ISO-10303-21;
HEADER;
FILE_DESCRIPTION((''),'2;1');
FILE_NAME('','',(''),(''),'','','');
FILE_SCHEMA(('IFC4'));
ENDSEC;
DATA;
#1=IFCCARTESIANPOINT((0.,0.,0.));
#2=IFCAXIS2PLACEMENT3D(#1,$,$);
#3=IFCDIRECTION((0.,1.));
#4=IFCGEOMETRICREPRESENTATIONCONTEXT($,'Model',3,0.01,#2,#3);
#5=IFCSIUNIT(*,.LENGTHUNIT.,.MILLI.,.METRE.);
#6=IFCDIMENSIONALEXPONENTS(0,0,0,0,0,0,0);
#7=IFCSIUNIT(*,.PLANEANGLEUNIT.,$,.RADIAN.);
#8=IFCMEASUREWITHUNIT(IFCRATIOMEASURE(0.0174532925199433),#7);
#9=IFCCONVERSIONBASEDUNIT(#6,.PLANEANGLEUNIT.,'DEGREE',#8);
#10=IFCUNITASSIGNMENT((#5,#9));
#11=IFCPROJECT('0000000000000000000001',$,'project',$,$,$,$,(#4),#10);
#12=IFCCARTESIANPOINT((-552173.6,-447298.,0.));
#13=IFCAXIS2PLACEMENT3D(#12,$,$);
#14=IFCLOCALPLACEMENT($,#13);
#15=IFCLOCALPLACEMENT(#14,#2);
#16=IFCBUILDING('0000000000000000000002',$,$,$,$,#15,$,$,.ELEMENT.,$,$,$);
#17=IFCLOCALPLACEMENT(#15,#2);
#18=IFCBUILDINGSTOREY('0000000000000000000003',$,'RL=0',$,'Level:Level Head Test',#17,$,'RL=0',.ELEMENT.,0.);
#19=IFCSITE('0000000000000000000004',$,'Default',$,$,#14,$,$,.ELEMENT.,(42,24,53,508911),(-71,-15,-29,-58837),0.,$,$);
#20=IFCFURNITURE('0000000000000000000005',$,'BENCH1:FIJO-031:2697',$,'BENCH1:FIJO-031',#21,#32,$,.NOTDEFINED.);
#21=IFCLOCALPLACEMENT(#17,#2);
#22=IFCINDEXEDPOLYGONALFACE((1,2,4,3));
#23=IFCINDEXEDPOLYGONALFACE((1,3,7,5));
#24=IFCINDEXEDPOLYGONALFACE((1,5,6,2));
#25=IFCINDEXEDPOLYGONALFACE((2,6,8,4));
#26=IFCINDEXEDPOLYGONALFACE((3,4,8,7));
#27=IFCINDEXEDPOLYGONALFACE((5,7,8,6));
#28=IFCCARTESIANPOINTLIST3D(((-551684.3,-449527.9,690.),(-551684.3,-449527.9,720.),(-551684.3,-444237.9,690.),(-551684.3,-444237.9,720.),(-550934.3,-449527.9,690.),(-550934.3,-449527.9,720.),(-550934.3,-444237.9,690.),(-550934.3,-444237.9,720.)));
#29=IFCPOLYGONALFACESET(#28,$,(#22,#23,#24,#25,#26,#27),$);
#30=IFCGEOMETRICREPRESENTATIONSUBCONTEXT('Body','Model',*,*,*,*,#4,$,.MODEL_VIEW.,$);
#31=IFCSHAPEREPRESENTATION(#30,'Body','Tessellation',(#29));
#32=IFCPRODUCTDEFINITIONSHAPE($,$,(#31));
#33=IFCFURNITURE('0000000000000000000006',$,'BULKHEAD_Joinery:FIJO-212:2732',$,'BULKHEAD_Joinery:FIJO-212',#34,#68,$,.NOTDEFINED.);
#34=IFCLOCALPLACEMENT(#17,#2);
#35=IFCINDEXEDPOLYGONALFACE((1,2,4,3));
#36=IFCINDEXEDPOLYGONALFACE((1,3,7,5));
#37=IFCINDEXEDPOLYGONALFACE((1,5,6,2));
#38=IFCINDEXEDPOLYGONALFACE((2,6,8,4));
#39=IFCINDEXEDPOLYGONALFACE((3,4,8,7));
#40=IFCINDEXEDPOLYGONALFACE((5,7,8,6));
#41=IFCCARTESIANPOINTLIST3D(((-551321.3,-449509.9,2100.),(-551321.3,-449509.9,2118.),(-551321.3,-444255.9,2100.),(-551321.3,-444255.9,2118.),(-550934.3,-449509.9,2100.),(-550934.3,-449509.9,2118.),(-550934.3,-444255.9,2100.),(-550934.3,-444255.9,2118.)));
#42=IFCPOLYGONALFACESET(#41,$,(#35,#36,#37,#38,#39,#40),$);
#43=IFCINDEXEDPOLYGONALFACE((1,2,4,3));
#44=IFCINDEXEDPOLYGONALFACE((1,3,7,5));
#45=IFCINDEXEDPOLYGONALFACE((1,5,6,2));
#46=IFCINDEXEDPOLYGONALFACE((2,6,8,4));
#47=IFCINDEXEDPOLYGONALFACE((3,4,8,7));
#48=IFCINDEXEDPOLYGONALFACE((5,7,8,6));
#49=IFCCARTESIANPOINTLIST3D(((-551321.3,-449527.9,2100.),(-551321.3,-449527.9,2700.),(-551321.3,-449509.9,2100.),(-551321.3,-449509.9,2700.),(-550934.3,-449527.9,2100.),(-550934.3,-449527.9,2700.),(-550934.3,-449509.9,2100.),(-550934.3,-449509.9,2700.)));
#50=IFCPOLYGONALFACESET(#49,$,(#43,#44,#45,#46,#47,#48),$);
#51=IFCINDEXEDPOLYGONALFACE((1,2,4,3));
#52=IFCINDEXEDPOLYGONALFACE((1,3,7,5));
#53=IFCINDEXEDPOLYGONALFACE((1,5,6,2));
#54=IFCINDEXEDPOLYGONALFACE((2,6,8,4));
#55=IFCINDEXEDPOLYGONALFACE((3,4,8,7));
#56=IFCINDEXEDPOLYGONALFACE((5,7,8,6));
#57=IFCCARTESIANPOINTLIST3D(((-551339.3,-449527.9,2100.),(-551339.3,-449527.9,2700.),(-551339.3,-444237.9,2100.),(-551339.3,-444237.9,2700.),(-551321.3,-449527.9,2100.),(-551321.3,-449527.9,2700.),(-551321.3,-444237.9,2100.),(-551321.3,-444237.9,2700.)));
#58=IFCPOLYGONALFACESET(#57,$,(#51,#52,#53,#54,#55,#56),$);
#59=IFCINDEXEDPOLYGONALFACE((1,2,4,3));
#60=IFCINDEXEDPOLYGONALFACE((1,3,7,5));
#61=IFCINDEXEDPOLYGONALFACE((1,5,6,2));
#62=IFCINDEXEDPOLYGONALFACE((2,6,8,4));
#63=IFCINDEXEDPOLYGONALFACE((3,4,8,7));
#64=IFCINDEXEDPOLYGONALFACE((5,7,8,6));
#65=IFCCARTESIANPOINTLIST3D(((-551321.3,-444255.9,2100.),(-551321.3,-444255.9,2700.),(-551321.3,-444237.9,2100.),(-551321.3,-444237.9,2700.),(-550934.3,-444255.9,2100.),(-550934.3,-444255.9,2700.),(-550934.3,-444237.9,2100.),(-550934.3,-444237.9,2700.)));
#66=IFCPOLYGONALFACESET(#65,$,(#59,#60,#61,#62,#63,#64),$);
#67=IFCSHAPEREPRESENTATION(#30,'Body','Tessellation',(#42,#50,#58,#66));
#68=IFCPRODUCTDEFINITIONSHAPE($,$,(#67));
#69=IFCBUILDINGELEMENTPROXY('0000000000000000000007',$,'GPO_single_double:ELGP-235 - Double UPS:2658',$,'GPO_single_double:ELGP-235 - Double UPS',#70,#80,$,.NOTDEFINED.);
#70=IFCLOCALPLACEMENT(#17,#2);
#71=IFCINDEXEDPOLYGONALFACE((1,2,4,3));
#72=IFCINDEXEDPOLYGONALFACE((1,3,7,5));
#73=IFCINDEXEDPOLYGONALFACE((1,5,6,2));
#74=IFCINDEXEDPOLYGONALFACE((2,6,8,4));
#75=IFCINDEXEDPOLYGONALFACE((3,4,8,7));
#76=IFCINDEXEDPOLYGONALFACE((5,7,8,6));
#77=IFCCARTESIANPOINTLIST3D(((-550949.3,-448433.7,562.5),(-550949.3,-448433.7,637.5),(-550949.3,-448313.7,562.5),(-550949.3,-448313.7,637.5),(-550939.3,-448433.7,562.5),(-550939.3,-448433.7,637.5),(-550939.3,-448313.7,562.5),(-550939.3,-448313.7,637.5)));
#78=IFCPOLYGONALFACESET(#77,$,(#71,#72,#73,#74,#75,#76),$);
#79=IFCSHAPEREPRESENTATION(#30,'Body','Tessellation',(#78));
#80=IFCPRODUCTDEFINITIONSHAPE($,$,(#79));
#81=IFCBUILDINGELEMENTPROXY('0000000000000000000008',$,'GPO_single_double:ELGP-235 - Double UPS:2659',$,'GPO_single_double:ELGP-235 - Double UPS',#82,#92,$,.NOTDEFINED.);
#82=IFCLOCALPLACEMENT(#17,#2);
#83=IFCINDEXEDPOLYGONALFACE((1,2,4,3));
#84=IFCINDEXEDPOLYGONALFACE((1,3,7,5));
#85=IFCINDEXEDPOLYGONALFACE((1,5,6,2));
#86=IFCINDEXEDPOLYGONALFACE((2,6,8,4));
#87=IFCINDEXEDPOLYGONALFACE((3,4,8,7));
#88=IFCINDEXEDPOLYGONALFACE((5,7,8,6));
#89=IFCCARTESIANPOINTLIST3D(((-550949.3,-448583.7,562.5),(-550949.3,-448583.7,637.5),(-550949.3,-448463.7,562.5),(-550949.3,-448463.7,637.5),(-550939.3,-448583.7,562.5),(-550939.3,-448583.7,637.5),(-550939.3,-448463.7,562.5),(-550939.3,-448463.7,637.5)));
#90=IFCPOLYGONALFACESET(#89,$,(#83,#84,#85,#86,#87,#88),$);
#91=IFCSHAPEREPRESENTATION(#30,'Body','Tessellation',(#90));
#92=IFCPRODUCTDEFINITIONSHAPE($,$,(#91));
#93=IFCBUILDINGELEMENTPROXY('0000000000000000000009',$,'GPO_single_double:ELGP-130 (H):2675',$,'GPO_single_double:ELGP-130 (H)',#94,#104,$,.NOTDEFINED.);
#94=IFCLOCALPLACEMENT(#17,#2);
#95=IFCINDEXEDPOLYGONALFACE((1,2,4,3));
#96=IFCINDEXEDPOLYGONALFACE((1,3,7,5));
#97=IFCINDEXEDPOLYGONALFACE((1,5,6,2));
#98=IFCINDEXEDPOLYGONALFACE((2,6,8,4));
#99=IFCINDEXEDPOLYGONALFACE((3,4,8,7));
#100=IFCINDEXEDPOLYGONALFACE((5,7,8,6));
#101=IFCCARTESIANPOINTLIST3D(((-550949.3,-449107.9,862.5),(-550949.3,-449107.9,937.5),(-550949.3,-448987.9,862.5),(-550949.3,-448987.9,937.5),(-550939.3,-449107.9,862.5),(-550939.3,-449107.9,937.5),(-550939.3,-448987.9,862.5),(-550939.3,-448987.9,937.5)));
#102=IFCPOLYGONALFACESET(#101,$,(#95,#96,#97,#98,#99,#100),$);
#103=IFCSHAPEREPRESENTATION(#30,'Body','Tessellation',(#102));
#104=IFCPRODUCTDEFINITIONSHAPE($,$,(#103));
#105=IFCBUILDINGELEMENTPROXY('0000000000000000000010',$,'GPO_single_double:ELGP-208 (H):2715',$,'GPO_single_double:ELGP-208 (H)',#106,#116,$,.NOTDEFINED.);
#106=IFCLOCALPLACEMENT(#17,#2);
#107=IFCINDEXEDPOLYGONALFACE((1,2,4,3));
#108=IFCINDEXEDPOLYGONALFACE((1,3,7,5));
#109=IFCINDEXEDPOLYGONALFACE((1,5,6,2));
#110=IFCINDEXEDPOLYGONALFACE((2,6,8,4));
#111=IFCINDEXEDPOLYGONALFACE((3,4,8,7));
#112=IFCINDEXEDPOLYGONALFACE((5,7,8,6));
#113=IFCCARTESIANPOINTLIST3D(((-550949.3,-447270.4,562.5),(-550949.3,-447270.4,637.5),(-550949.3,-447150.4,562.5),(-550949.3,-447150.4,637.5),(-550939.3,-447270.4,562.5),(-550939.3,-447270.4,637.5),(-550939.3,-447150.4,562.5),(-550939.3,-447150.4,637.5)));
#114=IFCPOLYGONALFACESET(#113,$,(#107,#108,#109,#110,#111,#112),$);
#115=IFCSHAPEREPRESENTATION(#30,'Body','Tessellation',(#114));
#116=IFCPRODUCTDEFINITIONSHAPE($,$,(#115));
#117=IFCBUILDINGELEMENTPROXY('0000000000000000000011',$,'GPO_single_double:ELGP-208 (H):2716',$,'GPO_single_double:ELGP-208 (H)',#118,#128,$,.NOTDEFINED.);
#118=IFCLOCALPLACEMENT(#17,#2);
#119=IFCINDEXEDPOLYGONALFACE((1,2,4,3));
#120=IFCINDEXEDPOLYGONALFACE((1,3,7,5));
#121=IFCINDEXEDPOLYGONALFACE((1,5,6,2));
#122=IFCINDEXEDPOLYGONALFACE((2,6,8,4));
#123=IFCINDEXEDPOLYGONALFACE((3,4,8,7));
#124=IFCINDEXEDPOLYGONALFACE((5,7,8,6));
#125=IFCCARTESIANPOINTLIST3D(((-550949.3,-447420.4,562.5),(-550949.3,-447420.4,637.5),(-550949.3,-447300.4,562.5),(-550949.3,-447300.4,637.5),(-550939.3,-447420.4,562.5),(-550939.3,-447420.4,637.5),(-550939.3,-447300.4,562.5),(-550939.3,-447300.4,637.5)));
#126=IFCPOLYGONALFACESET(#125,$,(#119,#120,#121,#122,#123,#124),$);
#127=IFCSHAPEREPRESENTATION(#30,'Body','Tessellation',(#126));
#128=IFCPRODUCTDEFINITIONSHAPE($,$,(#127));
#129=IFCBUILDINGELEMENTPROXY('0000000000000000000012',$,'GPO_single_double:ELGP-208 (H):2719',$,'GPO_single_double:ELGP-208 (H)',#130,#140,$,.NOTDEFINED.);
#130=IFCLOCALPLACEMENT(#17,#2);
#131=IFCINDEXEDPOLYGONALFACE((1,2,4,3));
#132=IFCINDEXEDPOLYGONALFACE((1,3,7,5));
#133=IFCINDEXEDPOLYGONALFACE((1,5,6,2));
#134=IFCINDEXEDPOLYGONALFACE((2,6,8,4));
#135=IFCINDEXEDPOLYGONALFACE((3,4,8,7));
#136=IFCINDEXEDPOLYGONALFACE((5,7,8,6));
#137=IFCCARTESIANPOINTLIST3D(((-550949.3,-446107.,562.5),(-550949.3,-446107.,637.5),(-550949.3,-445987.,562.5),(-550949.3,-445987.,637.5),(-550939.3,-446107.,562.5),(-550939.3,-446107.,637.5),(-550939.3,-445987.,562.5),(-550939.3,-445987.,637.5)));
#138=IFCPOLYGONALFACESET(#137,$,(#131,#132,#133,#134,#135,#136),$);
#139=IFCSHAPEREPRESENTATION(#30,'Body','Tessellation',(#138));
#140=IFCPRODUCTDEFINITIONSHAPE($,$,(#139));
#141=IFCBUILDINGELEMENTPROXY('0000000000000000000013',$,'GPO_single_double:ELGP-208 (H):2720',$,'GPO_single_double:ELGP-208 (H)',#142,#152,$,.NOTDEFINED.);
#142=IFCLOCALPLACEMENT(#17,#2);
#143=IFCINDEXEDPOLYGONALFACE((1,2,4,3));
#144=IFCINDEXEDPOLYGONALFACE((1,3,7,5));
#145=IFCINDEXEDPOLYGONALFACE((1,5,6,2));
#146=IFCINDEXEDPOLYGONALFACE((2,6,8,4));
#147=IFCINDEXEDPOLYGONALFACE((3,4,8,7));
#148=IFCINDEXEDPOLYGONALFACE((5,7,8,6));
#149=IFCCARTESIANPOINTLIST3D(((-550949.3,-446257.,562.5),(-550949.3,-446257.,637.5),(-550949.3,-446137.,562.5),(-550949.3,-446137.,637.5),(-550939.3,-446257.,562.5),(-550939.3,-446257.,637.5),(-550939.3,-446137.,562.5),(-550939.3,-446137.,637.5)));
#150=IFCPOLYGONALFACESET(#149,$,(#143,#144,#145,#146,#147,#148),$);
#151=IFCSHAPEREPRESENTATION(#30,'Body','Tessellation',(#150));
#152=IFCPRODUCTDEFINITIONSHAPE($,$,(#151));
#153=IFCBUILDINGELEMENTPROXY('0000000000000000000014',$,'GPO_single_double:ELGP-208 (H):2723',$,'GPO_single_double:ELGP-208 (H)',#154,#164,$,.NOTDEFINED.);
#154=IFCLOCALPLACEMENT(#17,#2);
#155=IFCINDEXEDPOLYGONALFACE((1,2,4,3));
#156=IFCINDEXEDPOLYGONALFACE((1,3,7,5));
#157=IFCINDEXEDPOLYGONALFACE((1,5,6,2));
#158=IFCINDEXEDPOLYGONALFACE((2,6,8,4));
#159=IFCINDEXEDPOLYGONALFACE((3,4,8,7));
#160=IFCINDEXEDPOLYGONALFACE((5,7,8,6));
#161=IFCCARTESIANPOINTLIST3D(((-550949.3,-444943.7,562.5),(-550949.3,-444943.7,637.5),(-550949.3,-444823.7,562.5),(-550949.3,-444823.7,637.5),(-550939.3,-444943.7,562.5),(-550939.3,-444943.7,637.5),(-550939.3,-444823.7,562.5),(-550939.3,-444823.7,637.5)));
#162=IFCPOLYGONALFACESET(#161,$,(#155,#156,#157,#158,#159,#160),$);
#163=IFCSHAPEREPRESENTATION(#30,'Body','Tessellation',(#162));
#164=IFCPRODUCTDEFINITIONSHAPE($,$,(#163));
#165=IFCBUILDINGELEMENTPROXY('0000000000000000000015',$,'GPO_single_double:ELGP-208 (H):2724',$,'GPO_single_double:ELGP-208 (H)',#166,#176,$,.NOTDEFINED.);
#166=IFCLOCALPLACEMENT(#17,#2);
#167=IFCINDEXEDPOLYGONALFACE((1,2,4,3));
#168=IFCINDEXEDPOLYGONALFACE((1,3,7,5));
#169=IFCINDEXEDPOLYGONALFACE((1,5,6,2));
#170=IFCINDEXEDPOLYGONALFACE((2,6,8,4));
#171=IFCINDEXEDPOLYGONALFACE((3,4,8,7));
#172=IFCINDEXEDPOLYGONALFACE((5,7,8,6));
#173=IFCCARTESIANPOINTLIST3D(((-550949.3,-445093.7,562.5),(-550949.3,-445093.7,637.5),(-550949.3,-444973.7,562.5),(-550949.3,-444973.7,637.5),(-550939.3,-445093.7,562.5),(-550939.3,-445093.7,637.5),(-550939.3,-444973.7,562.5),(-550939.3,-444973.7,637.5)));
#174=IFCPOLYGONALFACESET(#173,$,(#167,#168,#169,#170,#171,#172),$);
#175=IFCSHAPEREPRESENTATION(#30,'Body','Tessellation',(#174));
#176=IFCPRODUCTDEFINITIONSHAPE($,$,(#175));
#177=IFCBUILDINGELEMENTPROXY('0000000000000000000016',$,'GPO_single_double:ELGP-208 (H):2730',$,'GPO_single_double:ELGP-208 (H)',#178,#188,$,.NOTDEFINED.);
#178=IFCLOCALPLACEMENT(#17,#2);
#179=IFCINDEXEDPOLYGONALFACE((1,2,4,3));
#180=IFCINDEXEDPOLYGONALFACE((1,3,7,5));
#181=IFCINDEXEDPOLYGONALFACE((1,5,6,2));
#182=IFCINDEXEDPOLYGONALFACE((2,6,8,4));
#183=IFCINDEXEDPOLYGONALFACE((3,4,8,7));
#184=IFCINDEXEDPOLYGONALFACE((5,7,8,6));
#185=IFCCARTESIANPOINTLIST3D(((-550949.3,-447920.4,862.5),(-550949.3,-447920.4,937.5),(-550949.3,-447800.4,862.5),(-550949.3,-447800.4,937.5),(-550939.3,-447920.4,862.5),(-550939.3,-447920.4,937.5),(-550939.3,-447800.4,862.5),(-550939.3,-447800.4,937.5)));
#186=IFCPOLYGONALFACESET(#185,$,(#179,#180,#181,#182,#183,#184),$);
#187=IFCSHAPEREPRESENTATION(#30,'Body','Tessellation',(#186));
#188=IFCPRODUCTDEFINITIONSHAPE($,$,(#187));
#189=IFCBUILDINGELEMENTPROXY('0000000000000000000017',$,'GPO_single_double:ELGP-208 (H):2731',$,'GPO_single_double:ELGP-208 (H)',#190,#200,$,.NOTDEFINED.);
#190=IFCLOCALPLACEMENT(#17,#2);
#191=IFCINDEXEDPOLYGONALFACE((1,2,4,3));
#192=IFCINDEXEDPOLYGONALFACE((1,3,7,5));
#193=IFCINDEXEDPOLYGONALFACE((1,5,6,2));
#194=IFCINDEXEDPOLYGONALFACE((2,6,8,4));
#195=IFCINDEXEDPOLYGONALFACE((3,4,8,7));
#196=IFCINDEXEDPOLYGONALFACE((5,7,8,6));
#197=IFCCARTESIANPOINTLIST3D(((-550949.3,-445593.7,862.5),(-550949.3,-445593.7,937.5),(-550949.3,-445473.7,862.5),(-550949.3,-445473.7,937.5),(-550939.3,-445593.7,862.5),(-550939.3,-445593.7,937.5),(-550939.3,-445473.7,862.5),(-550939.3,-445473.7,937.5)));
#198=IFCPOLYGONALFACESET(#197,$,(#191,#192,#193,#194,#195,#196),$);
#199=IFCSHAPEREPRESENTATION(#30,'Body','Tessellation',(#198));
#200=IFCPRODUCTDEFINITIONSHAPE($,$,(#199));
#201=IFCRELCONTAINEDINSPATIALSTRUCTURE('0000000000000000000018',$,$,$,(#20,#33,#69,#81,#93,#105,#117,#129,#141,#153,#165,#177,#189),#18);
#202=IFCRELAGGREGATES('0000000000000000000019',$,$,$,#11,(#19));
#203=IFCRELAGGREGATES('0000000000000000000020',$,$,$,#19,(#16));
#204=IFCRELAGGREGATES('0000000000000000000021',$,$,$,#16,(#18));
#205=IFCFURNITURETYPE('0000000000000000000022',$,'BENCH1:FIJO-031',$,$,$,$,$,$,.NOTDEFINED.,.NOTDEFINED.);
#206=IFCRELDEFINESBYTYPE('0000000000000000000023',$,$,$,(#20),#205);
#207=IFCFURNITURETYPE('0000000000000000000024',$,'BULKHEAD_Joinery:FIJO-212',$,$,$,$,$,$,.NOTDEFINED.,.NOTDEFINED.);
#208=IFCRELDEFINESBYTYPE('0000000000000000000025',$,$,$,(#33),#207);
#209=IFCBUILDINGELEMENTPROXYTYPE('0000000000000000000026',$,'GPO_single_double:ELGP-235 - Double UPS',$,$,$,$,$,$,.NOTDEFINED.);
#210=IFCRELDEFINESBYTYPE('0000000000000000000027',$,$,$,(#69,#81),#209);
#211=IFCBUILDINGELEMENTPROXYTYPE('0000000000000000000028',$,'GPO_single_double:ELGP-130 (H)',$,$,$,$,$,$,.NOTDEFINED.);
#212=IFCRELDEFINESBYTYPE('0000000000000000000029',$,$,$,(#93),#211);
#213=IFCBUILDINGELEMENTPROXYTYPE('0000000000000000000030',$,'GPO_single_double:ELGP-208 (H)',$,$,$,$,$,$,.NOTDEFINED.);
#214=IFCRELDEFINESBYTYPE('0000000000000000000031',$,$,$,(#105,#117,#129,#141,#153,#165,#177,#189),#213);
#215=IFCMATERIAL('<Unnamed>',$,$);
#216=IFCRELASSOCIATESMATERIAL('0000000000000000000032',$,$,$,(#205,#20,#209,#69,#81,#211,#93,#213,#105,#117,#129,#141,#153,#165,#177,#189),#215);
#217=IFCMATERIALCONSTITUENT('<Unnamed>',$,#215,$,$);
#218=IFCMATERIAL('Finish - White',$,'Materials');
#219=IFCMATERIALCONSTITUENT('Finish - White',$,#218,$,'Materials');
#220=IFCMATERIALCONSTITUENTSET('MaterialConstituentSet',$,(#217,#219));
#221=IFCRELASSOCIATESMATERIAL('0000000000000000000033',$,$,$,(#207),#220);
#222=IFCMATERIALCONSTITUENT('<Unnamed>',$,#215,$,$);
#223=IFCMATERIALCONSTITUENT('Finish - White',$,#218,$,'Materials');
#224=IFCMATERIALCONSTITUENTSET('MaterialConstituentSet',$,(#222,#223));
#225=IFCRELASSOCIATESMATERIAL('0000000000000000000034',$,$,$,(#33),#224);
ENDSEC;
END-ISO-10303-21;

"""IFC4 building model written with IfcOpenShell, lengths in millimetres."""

from ifc_helpers import new_model, entity, si_unit, converted_unit, direction, frame, origin, place, context, subcontext, project, spatial, indexed_curve, outline, extrude, source, transform, mapped, material, constituent, constituent_set, type_object, type_shapes, element, save


model = new_model("IFC4")

# Units and contexts
model_context = context("Model", 3, precision=0.01, world=origin(), true_north=direction((0.0, 1.0)))
body_context = subcontext(model_context, "Body", "Model", "MODEL_VIEW")
ifc_project = project(units=[si_unit("LENGTHUNIT", "METRE", prefix="MILLI"), converted_unit("PLANEANGLEUNIT", "DEGREE", entity("IfcRatioMeasure", 0.0174532925199433), si_unit("PLANEANGLEUNIT", "RADIAN"), dimensions=[0, 0, 0, 0, 0, 0, 0])], contexts=[model_context])

# Site, building, storey
site_placement = place(None, frame((-552173.6, -447298.0, 0.0)))
site = spatial("IfcSite", under=ifc_project, at=site_placement, Name="Default", CompositionType="ELEMENT", RefLatitude=(42, 24, 53, 508911), RefLongitude=(-71, -15, -29, -58837), RefElevation=0.0)
building_placement = place(site_placement, origin())
building = spatial("IfcBuilding", under=site, at=building_placement, CompositionType="ELEMENT")
storey_placement = place(building_placement, origin())
storey = spatial("IfcBuildingStorey", under=building, at=storey_placement, Name="RL=0", ObjectType="Level:Level Head Test", LongName="RL=0", CompositionType="ELEMENT", Elevation=0.0)

# Shared definitions
ifc_material_1 = material(Name="<Unnamed>")

# Furniture
furniture_type_1 = type_object("IfcFurnitureType", Name="BENCH1:FIJO-031", AssemblyPlace="NOTDEFINED", PredefinedType="NOTDEFINED", material=ifc_material_1)
shared_shape_1 = source(origin(), body_context, "Body", "SweptSolid", [
    extrude(outline(indexed_curve([(-375.0, -2645.0), (375.0, -2645.0), (375.0, 2645.0), (-375.0, 2645.0), (-375.0, -2645.0)], self_intersect=False)), frame((2645.0, 375.0, 0.0), z_axis=(0.0, 0.0, 1.0), x_axis=(0.0, 1.0, 0.0)), (0.0, 0.0, 1.0), 30.0),
])
type_shapes(furniture_type_1, [shared_shape_1])
furniture_1_placement = place(storey_placement, frame((-550934.3, -449527.9, 690.0), z_axis=(0.0, 0.0, 1.0), x_axis=(0.0, 1.0, 0.0)))
element("IfcFurniture", 1, at=furniture_1_placement, inside=storey, type_object=furniture_type_1, material=ifc_material_1, Name="BENCH1:FIJO-031:2697", ObjectType="BENCH1:FIJO-031", PredefinedType="NOTDEFINED", context=body_context, shape_type="MappedRepresentation", body=[
    mapped(shared_shape_1, transform((0.0, 0.0, 0.0), scale=1.0)),
])
ifc_constituent_1 = constituent(ifc_material_1, Name="<Unnamed>")
ifc_material_2 = material(Name="Finish - White", Category="Materials")
ifc_constituent_2 = constituent(ifc_material_2, Name="Finish - White", Category="Materials")
ifc_constituent_set_1 = constituent_set(constituents=[ifc_constituent_1, ifc_constituent_2], Name="MaterialConstituentSet")
ifc_constituent_3 = constituent(ifc_material_1, Name="<Unnamed>")
ifc_constituent_4 = constituent(ifc_material_2, Name="Finish - White", Category="Materials")
ifc_constituent_set_2 = constituent_set(constituents=[ifc_constituent_3, ifc_constituent_4], Name="MaterialConstituentSet")
furniture_type_2 = type_object("IfcFurnitureType", Name="BULKHEAD_Joinery:FIJO-212", AssemblyPlace="NOTDEFINED", PredefinedType="NOTDEFINED", material=ifc_constituent_set_2)
shared_shape_2 = source(origin(), body_context, "Body", "SweptSolid", [
    extrude(outline(indexed_curve([(-2627.0, -193.5), (2627.0, -193.5), (2627.0, 193.5), (-2627.0, 193.5), (-2627.0, -193.5)], self_intersect=False)), frame((2645.0, 211.5, 0.0), z_axis=(0.0, 0.0, 1.0), x_axis=(-1.0, 0.0, 0.0)), (0.0, 0.0, 1.0), 18.0),
    extrude(outline(indexed_curve([(-9.0, -193.5), (9.0, -193.5), (9.0, 193.5), (-9.0, 193.5), (-9.0, -193.5)], self_intersect=False)), frame((5281.0, 211.5, 0.0), z_axis=(0.0, 0.0, 1.0), x_axis=(-1.0, 0.0, 0.0)), (0.0, 0.0, 1.0), 600.0),
    extrude(outline(indexed_curve([(-2645.0, -9.0), (2645.0, -9.0), (2645.0, 9.0), (-2645.0, 9.0), (-2645.0, -9.0)], self_intersect=False)), frame((2645.0, 9.0, 0.0), z_axis=(0.0, 0.0, 1.0), x_axis=(-1.0, 0.0, 0.0)), (0.0, 0.0, 1.0), 600.0),
    extrude(outline(indexed_curve([(-9.0, -193.5), (9.0, -193.5), (9.0, 193.5), (-9.0, 193.5), (-9.0, -193.5)], self_intersect=False)), frame((9.0, 211.5, 0.0), z_axis=(0.0, 0.0, 1.0), x_axis=(-1.0, 0.0, 0.0)), (0.0, 0.0, 1.0), 600.0),
])
type_shapes(furniture_type_2, [shared_shape_2])
furniture_2_placement = place(storey_placement, frame((-551339.3, -444237.9, 2100.0), z_axis=(0.0, 0.0, 1.0), x_axis=(0.0, -1.0, 0.0)))
element("IfcFurniture", 2, at=furniture_2_placement, inside=storey, type_object=furniture_type_2, material=ifc_constituent_set_1, Name="BULKHEAD_Joinery:FIJO-212:2732", ObjectType="BULKHEAD_Joinery:FIJO-212", PredefinedType="NOTDEFINED", context=body_context, shape_type="MappedRepresentation", body=[
    mapped(shared_shape_2, transform((0.0, 0.0, 0.0), scale=1.0)),
])

# Building element proxies
building_element_proxy_type_1 = type_object("IfcBuildingElementProxyType", Name="GPO_single_double:ELGP-235 - Double UPS", PredefinedType="NOTDEFINED", material=ifc_material_1)
shared_shape_3 = source(origin(), body_context, "Body", "SweptSolid", [
    extrude(outline(indexed_curve([(-5.0, -60.0), (5.0, -60.0), (5.0, 60.0), (-5.0, 60.0), (-5.0, -60.0)], self_intersect=False)), frame((0.0, -5.0, -37.5), z_axis=(0.0, 0.0, 1.0), x_axis=(0.0, 1.0, 0.0)), (0.0, 0.0, 1.0), 75.0),
])
type_shapes(building_element_proxy_type_1, [shared_shape_3])
for number, where, z_axis, x_axis, name in (
    (3, (-550939.3, -448373.7, 600.0), (0.0, 0.0, 1.0), (0.0, -1.0, 0.0), "GPO_single_double:ELGP-235 - Double UPS:2658"),
    (4, (-550939.3, -448523.7, 600.0), (0.0, 0.0, 1.0), (0.0, -1.0, 0.0), "GPO_single_double:ELGP-235 - Double UPS:2659"),
):
    element("IfcBuildingElementProxy", number, at=place(storey_placement, frame(where, z_axis=z_axis, x_axis=x_axis)), inside=storey, type_object=building_element_proxy_type_1, material=ifc_material_1, Name=name, ObjectType="GPO_single_double:ELGP-235 - Double UPS", PredefinedType="NOTDEFINED", context=body_context, shape_type="MappedRepresentation", body=[
        mapped(shared_shape_3, transform((0.0, 0.0, 0.0), scale=1.0)),
    ])
building_element_proxy_type_2 = type_object("IfcBuildingElementProxyType", Name="GPO_single_double:ELGP-130 (H)", PredefinedType="NOTDEFINED", material=ifc_material_1)
shared_shape_4 = source(origin(), body_context, "Body", "SweptSolid", [
    extrude(outline(indexed_curve([(-5.0, -60.0), (5.0, -60.0), (5.0, 60.0), (-5.0, 60.0), (-5.0, -60.0)], self_intersect=False)), frame((60.0, 5.0, 0.0), z_axis=(0.0, 0.0, 1.0), x_axis=(0.0, 1.0, 0.0)), (0.0, 0.0, 1.0), 75.0),
])
type_shapes(building_element_proxy_type_2, [shared_shape_4])
proxy_placement = place(storey_placement, frame((-550949.3, -448987.9, 862.5), z_axis=(0.0, 0.0, 1.0), x_axis=(0.0, -1.0, 0.0)))
element("IfcBuildingElementProxy", 5, at=proxy_placement, inside=storey, type_object=building_element_proxy_type_2, material=ifc_material_1, Name="GPO_single_double:ELGP-130 (H):2675", ObjectType="GPO_single_double:ELGP-130 (H)", PredefinedType="NOTDEFINED", context=body_context, shape_type="MappedRepresentation", body=[
    mapped(shared_shape_4, transform((0.0, 0.0, 0.0), scale=1.0)),
])
building_element_proxy_type_3 = type_object("IfcBuildingElementProxyType", Name="GPO_single_double:ELGP-208 (H)", PredefinedType="NOTDEFINED", material=ifc_material_1)
shared_shape_5 = source(origin(), body_context, "Body", "SweptSolid", [
    extrude(outline(indexed_curve([(-5.0, -60.0), (5.0, -60.0), (5.0, 60.0), (-5.0, 60.0), (-5.0, -60.0)], self_intersect=False)), frame((0.0, -5.0, -37.5), z_axis=(0.0, 0.0, 1.0), x_axis=(0.0, 1.0, 0.0)), (0.0, 0.0, 1.0), 75.0),
])
type_shapes(building_element_proxy_type_3, [shared_shape_5])
for number, where, z_axis, x_axis, name in (
    (6, (-550939.3, -447210.4, 600.0), (0.0, 0.0, 1.0), (0.0, -1.0, 0.0), "GPO_single_double:ELGP-208 (H):2715"),
    (7, (-550939.3, -447360.4, 600.0), (0.0, 0.0, 1.0), (0.0, -1.0, 0.0), "GPO_single_double:ELGP-208 (H):2716"),
    (8, (-550939.3, -446047.0, 600.0), (0.0, 0.0, 1.0), (0.0, -1.0, 0.0), "GPO_single_double:ELGP-208 (H):2719"),
    (9, (-550939.3, -446197.0, 600.0), (0.0, 0.0, 1.0), (0.0, -1.0, 0.0), "GPO_single_double:ELGP-208 (H):2720"),
    (10, (-550939.3, -444883.7, 600.0), (0.0, 0.0, 1.0), (0.0, -1.0, 0.0), "GPO_single_double:ELGP-208 (H):2723"),
    (11, (-550939.3, -445033.7, 600.0), (0.0, 0.0, 1.0), (0.0, -1.0, 0.0), "GPO_single_double:ELGP-208 (H):2724"),
    (12, (-550939.3, -447860.4, 900.0), (0.0, 0.0, 1.0), (0.0, -1.0, 0.0), "GPO_single_double:ELGP-208 (H):2730"),
    (13, (-550939.3, -445533.7, 900.0), (0.0, 0.0, 1.0), (0.0, -1.0, 0.0), "GPO_single_double:ELGP-208 (H):2731"),
):
    element("IfcBuildingElementProxy", number, at=place(storey_placement, frame(where, z_axis=z_axis, x_axis=x_axis)), inside=storey, type_object=building_element_proxy_type_3, material=ifc_material_1, Name=name, ObjectType="GPO_single_double:ELGP-208 (H)", PredefinedType="NOTDEFINED", context=body_context, shape_type="MappedRepresentation", body=[
        mapped(shared_shape_5, transform((0.0, 0.0, 0.0), scale=1.0)),
    ])

save(model, "model.ifc")
